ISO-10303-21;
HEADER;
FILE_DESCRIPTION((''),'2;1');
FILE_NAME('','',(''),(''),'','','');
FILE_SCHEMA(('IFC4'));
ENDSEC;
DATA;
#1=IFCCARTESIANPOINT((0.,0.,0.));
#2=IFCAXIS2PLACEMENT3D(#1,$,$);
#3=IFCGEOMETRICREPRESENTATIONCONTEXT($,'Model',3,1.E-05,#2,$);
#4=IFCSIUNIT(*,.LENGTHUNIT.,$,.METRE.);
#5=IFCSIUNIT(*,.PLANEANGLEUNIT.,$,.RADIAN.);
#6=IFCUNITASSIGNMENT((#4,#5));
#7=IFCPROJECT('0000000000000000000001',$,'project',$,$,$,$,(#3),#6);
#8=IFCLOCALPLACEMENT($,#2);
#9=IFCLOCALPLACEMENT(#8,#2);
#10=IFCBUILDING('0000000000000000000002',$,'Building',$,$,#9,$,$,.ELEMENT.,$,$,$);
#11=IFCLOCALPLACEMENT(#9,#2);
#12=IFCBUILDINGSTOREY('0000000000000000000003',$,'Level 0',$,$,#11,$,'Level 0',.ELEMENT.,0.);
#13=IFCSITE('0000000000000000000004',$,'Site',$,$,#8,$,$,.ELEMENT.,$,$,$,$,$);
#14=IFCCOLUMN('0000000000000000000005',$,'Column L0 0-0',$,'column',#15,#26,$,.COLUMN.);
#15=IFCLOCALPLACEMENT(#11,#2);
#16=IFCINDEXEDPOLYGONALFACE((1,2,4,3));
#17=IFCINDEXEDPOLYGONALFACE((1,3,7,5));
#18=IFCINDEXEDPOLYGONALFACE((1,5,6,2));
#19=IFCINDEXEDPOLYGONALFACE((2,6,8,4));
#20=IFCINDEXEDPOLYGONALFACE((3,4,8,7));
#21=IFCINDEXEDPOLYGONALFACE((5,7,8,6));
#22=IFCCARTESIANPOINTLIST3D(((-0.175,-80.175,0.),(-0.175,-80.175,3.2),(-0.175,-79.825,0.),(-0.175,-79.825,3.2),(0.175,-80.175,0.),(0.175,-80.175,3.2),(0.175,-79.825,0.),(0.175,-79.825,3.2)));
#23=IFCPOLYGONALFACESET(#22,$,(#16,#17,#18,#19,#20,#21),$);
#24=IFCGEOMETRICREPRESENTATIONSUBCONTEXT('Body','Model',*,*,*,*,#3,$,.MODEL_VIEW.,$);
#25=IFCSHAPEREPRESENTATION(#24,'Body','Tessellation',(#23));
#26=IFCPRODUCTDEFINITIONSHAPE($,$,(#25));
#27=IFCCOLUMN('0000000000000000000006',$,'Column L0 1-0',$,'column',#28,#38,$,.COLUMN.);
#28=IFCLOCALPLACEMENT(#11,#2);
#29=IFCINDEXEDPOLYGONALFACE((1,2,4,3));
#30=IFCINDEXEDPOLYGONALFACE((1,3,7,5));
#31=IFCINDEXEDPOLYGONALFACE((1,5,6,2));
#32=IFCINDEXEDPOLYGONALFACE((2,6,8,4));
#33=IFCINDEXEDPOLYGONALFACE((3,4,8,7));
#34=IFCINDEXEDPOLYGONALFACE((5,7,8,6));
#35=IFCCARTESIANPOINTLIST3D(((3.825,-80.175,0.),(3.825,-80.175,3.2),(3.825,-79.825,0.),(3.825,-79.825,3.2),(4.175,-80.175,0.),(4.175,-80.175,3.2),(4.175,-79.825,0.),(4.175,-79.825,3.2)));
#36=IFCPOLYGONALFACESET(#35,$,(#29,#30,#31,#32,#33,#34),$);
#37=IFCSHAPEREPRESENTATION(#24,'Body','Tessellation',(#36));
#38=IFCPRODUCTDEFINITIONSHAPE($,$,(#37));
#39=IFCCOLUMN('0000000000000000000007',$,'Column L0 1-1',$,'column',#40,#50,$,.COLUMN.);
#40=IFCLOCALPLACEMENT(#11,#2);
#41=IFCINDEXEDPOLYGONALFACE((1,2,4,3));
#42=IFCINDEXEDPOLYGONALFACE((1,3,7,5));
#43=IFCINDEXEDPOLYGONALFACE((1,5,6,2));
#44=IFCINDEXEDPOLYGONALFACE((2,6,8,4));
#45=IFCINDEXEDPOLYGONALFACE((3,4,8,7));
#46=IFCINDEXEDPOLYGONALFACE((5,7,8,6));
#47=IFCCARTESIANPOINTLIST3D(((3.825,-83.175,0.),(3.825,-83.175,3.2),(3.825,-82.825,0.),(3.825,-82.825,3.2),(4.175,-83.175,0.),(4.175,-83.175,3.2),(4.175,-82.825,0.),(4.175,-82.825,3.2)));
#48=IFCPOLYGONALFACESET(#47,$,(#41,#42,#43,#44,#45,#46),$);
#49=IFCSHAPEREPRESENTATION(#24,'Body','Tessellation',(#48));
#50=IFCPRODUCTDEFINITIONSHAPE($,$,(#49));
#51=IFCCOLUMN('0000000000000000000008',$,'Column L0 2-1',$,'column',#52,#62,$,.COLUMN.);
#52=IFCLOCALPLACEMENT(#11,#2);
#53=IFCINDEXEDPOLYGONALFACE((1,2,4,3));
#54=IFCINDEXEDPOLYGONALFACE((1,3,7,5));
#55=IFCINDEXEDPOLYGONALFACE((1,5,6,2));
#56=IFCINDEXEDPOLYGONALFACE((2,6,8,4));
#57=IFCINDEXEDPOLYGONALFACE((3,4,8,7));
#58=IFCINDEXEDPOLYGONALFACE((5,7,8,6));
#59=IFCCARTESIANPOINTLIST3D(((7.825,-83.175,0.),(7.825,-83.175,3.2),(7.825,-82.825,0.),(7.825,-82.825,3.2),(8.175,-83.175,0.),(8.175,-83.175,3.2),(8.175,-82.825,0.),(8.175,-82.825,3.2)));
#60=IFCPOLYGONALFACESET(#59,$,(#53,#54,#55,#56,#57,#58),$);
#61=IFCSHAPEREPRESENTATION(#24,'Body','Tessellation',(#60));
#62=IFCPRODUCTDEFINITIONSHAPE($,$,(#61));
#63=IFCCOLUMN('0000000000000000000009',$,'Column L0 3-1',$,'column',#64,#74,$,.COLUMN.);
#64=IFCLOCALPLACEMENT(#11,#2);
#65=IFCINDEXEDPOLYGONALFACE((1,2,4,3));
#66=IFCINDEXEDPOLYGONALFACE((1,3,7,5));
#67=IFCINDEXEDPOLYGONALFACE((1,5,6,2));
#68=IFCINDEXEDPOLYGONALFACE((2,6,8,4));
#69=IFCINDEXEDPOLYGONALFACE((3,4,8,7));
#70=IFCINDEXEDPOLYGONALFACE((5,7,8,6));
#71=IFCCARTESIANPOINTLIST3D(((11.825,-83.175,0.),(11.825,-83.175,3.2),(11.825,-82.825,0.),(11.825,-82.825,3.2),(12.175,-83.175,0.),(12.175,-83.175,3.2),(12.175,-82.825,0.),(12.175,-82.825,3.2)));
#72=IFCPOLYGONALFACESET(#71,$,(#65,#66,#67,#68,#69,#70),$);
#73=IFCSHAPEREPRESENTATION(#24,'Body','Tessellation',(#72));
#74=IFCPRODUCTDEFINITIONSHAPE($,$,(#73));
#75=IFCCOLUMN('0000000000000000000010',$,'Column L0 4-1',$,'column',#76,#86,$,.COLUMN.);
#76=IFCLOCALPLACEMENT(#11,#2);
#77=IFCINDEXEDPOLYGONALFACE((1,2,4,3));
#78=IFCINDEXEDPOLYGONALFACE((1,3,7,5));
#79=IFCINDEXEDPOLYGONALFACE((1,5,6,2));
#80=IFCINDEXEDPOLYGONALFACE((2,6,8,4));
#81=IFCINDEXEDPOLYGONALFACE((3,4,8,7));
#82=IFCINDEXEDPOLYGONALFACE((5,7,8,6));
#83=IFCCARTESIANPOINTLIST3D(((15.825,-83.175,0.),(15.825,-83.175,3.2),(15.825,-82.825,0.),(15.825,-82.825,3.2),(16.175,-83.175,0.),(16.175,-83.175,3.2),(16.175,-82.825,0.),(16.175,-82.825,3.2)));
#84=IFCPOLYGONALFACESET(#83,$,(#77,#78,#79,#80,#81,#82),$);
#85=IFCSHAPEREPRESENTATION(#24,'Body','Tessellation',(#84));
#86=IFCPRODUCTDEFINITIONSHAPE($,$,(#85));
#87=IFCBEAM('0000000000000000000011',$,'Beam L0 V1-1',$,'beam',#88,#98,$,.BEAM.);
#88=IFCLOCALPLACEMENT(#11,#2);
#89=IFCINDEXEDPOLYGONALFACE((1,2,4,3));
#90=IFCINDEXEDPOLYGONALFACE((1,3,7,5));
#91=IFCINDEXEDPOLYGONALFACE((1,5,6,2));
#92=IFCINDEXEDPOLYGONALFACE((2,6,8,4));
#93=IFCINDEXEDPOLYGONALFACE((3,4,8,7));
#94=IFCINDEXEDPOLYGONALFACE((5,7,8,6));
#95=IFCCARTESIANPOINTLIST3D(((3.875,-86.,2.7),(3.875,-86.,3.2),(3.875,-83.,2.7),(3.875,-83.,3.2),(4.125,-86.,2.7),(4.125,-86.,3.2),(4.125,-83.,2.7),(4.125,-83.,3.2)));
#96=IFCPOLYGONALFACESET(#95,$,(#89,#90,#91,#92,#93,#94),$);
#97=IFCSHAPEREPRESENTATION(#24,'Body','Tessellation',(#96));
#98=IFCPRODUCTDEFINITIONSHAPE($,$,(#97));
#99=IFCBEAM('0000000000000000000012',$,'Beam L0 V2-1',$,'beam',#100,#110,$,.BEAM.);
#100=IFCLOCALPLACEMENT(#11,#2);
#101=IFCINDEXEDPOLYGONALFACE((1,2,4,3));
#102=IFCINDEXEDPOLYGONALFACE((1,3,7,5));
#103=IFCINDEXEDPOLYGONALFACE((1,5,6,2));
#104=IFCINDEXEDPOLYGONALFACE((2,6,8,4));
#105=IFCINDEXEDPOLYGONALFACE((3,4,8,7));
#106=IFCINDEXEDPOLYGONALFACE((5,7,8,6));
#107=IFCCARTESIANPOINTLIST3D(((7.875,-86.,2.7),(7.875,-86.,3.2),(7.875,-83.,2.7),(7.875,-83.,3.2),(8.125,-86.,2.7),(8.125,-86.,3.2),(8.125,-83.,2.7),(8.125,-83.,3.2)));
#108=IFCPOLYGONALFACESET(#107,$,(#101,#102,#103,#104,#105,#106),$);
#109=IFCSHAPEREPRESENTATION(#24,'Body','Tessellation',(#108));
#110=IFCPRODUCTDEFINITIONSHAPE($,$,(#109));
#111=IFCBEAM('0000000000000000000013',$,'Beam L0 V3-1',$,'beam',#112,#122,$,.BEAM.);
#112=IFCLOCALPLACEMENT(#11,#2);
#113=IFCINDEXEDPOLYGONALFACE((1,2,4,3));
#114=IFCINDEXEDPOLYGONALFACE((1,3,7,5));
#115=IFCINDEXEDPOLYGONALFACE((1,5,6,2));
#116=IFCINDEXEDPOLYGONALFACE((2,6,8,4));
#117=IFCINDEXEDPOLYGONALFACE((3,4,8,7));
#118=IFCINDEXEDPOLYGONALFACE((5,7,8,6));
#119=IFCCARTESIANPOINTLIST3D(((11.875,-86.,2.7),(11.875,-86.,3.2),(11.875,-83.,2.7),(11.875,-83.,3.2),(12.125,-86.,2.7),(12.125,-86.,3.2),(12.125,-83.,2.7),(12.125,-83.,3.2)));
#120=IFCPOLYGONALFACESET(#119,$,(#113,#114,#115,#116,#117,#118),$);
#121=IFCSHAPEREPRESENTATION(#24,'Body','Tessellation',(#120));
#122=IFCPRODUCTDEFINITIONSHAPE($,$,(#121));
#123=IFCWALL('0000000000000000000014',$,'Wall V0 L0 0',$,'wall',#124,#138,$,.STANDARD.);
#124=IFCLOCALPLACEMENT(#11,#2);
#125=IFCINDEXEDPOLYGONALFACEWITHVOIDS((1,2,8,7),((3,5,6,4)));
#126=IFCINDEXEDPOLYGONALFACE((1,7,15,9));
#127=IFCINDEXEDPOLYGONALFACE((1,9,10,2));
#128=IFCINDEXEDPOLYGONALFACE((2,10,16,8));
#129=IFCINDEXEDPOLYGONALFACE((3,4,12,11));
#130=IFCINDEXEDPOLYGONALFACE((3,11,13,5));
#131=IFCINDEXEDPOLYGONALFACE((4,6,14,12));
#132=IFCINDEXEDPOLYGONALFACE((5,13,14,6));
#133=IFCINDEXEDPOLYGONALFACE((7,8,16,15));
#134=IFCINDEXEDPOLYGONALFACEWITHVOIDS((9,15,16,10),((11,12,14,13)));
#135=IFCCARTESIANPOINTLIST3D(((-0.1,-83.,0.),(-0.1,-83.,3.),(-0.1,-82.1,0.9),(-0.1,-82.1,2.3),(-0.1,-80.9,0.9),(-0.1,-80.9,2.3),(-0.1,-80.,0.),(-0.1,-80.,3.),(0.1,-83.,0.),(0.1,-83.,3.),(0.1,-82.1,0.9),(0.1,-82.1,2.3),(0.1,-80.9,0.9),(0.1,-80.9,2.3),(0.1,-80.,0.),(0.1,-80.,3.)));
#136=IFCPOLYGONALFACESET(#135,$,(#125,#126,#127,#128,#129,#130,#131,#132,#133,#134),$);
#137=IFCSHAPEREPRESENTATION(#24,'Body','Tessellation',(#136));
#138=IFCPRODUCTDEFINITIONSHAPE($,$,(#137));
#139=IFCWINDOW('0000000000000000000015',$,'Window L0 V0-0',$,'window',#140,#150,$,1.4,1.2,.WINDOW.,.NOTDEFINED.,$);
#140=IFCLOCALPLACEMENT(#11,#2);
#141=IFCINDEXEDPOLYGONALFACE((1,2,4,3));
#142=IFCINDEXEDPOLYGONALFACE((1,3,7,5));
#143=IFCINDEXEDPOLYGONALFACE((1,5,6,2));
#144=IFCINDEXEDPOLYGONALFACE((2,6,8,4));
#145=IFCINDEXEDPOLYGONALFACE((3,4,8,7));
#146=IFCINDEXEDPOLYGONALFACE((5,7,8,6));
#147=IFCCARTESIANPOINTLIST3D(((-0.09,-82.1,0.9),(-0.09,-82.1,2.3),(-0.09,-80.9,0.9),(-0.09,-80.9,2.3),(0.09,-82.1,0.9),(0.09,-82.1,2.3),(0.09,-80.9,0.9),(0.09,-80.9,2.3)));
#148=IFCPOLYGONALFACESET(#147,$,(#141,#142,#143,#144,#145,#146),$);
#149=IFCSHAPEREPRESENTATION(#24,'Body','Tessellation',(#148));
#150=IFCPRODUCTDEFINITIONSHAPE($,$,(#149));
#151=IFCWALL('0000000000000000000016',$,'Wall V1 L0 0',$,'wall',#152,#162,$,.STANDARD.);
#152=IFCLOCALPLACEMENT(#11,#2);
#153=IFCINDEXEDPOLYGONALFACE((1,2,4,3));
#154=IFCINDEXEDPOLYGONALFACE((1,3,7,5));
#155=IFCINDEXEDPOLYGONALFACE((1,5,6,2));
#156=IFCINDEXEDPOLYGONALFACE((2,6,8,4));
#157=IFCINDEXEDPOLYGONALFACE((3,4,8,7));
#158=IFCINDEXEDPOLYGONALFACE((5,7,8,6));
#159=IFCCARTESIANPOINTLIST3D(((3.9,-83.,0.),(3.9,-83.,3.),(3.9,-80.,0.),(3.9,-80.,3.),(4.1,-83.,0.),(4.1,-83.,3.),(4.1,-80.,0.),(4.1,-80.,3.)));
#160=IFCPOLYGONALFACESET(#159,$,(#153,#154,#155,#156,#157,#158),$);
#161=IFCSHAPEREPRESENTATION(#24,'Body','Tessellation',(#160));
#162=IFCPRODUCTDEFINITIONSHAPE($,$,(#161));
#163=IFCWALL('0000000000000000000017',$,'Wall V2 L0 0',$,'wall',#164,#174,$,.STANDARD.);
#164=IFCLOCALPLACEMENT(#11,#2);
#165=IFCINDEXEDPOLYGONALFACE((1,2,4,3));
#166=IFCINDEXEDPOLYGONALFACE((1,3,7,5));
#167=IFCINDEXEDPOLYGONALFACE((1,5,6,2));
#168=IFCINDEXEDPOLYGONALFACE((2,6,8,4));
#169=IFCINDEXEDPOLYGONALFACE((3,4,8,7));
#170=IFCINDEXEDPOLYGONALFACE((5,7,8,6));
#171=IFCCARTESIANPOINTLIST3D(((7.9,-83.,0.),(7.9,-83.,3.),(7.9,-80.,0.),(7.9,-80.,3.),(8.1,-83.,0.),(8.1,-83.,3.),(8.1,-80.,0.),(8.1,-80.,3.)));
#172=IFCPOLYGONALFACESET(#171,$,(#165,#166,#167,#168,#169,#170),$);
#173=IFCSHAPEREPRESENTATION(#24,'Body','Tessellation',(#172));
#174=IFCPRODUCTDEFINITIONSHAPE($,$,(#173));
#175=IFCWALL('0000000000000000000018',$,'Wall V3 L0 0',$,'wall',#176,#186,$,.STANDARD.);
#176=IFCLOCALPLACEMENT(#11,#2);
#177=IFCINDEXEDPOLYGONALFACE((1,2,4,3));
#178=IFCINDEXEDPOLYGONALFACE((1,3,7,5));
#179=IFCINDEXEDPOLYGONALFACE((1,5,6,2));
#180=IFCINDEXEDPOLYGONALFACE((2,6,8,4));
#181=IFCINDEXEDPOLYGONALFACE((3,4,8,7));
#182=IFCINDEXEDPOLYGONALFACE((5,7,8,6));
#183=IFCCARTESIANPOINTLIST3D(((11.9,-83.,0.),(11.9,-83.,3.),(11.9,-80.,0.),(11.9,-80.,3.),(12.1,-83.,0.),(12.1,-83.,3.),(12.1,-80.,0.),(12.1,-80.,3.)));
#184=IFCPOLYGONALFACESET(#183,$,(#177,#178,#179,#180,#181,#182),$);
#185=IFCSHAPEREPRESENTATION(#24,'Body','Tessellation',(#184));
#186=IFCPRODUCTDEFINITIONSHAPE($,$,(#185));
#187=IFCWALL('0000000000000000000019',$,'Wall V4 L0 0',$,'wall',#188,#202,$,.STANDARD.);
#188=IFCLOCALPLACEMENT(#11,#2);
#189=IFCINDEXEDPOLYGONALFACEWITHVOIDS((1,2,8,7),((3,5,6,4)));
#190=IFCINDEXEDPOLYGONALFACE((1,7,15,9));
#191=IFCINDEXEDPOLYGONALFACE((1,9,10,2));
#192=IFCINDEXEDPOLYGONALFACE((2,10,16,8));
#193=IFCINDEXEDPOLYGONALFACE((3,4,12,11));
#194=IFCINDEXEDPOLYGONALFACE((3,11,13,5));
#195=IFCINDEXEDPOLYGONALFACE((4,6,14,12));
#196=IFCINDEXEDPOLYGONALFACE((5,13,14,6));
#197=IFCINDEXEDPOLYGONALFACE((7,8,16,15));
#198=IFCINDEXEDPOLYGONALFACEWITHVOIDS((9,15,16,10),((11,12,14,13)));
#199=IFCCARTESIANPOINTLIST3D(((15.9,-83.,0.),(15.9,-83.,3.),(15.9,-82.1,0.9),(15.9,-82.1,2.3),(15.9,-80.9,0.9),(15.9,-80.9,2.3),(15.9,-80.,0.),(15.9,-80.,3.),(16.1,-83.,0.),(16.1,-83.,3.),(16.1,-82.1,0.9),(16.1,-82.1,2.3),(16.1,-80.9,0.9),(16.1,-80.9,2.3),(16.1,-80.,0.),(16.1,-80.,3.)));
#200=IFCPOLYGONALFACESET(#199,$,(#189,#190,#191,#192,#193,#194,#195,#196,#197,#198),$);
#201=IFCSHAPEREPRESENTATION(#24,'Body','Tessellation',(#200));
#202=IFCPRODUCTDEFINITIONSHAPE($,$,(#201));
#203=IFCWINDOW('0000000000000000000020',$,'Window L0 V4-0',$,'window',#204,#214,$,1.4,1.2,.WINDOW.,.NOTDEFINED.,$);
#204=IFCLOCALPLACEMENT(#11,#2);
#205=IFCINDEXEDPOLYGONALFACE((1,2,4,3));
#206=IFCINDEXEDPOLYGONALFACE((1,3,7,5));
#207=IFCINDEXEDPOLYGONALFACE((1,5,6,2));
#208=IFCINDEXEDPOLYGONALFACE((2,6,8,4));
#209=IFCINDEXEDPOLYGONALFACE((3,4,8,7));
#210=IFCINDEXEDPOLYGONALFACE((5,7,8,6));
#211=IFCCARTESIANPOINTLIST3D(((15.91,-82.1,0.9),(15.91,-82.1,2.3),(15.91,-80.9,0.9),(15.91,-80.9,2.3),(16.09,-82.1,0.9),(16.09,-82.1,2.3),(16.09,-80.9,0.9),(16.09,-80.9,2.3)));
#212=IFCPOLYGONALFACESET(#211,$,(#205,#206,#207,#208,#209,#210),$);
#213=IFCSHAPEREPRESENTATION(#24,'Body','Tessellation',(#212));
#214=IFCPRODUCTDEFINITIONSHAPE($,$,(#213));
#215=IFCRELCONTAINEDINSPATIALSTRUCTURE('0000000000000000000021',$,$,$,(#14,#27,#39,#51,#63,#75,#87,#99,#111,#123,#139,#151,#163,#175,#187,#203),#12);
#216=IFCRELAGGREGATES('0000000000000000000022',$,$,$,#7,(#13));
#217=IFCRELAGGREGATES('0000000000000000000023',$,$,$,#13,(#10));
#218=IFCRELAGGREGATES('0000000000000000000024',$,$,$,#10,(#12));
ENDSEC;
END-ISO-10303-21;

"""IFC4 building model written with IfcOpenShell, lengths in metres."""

from ifc_helpers import new_model, si_unit, frame, frame_2d, origin, origin_2d, place, context, subcontext, project, spatial, rectangle, extrude, element, fill, save


model = new_model("IFC4")

# Units and contexts
model_context = context("Model", 3, precision=1e-05, world=origin())
body_context = subcontext(model_context, "Body", "Model", "MODEL_VIEW")
ifc_project = project(units=[si_unit("LENGTHUNIT", "METRE"), si_unit("PLANEANGLEUNIT", "RADIAN")], contexts=[model_context])

# Site, building, storey
site_placement = place(None, origin())
site = spatial("IfcSite", under=ifc_project, at=site_placement, Name="Site", CompositionType="ELEMENT")
building_placement = place(site_placement, origin())
building = spatial("IfcBuilding", under=site, at=building_placement, Name="Building", CompositionType="ELEMENT")
storey_placement = place(building_placement, origin())
storey = spatial("IfcBuildingStorey", under=building, at=storey_placement, Name="Level 0", LongName="Level 0", CompositionType="ELEMENT", Elevation=0.0)

# Columns
for number, where, name in (
    (1, (0.0, -80.0, 0.0), "Column L0 0-0"),
    (2, (4.0, -80.0, 0.0), "Column L0 1-0"),
    (3, (4.0, -83.0, 0.0), "Column L0 1-1"),
    (4, (8.0, -83.0, 0.0), "Column L0 2-1"),
    (5, (12.0, -83.0, 0.0), "Column L0 3-1"),
    (6, (16.0, -83.0, 0.0), "Column L0 4-1"),
):
    element("IfcColumn", number, at=place(storey_placement, frame(where)), inside=storey, Name=name, ObjectType="column", PredefinedType="COLUMN", context=body_context, shape_type="SweptSolid", body=[
        extrude(rectangle(XDim=0.35, YDim=0.35, at=origin_2d()), origin(), (0.0, 0.0, 1.0), 3.2),
    ])

# Beams
for number, where, z_axis, x_axis, name in (
    (7, (4.0, -83.0, 2.95), (0.0, -1.0, 0.0), (0.0, 0.0, 1.0), "Beam L0 V1-1"),
    (8, (8.0, -83.0, 2.95), (0.0, -1.0, 0.0), (0.0, 0.0, 1.0), "Beam L0 V2-1"),
    (9, (12.0, -83.0, 2.95), (0.0, -1.0, 0.0), (0.0, 0.0, 1.0), "Beam L0 V3-1"),
):
    element("IfcBeam", number, at=place(storey_placement, frame(where, z_axis=z_axis, x_axis=x_axis)), inside=storey, Name=name, ObjectType="beam", PredefinedType="BEAM", context=body_context, shape_type="SweptSolid", body=[
        extrude(rectangle(XDim=0.5, YDim=0.25, at=origin_2d()), origin(), (0.0, 0.0, 1.0), 3.0),
    ])

# Wall, opening, window
wall_1_placement = place(storey_placement, frame((0.0, -80.0, 0.0), z_axis=(0.0, 0.0, 1.0), x_axis=(0.0, -1.0, 0.0)))
wall_1 = element("IfcWall", 10, at=wall_1_placement, inside=storey, Name="Wall V0 L0 0", ObjectType="wall", PredefinedType="STANDARD", context=body_context, shape_type="SweptSolid", body=[
    extrude(rectangle(XDim=3.0, YDim=0.2, at=frame_2d((1.5, 0.0))), origin(), (0.0, 0.0, 1.0), 3.0),
])
opening_1_placement = place(storey_placement, frame((0.0, -81.5, 0.9), z_axis=(0.0, 0.0, 1.0), x_axis=(0.0, -1.0, 0.0)))
opening_1 = element("IfcOpeningElement", 11, at=opening_1_placement, cuts=wall_1, ObjectType="Opening", PredefinedType="OPENING", context=body_context, shape_type="SweptSolid", body=[
    extrude(rectangle(XDim=1.2, YDim=0.22, at=origin_2d()), origin(), (0.0, 0.0, 1.0), 1.4),
])
window_1_placement = place(storey_placement, frame((0.0, -81.5, 0.9), z_axis=(0.0, 0.0, 1.0), x_axis=(0.0, -1.0, 0.0)))
window_1 = element("IfcWindow", 12, at=window_1_placement, inside=storey, Name="Window L0 V0-0", ObjectType="window", OverallHeight=1.4, OverallWidth=1.2, PartitioningType="NOTDEFINED", PredefinedType="WINDOW", context=body_context, shape_type="SweptSolid", body=[
    extrude(rectangle(XDim=1.2, YDim=0.18, at=origin_2d()), origin(), (0.0, 0.0, 1.0), 1.4),
])
fill(opening_1, window_1)

# Walls
for number, where, z_axis, x_axis, name in (
    (13, (4.0, -80.0, 0.0), (0.0, 0.0, 1.0), (0.0, -1.0, 0.0), "Wall V1 L0 0"),
    (14, (8.0, -80.0, 0.0), (0.0, 0.0, 1.0), (0.0, -1.0, 0.0), "Wall V2 L0 0"),
    (15, (12.0, -80.0, 0.0), (0.0, 0.0, 1.0), (0.0, -1.0, 0.0), "Wall V3 L0 0"),
):
    element("IfcWall", number, at=place(storey_placement, frame(where, z_axis=z_axis, x_axis=x_axis)), inside=storey, Name=name, ObjectType="wall", PredefinedType="STANDARD", context=body_context, shape_type="SweptSolid", body=[
        extrude(rectangle(XDim=3.0, YDim=0.2, at=frame_2d((1.5, 0.0))), origin(), (0.0, 0.0, 1.0), 3.0),
    ])

# Wall, opening, window
wall_2_placement = place(storey_placement, frame((16.0, -80.0, 0.0), z_axis=(0.0, 0.0, 1.0), x_axis=(0.0, -1.0, 0.0)))
wall_2 = element("IfcWall", 16, at=wall_2_placement, inside=storey, Name="Wall V4 L0 0", ObjectType="wall", PredefinedType="STANDARD", context=body_context, shape_type="SweptSolid", body=[
    extrude(rectangle(XDim=3.0, YDim=0.2, at=frame_2d((1.5, 0.0))), origin(), (0.0, 0.0, 1.0), 3.0),
])
opening_2_placement = place(storey_placement, frame((16.0, -81.5, 0.9), z_axis=(0.0, 0.0, 1.0), x_axis=(0.0, -1.0, 0.0)))
opening_2 = element("IfcOpeningElement", 17, at=opening_2_placement, cuts=wall_2, ObjectType="Opening", PredefinedType="OPENING", context=body_context, shape_type="SweptSolid", body=[
    extrude(rectangle(XDim=1.2, YDim=0.22, at=origin_2d()), origin(), (0.0, 0.0, 1.0), 1.4),
])
window_2_placement = place(storey_placement, frame((16.0, -81.5, 0.9), z_axis=(0.0, 0.0, 1.0), x_axis=(0.0, -1.0, 0.0)))
window_2 = element("IfcWindow", 18, at=window_2_placement, inside=storey, Name="Window L0 V4-0", ObjectType="window", OverallHeight=1.4, OverallWidth=1.2, PartitioningType="NOTDEFINED", PredefinedType="WINDOW", context=body_context, shape_type="SweptSolid", body=[
    extrude(rectangle(XDim=1.2, YDim=0.18, at=origin_2d()), origin(), (0.0, 0.0, 1.0), 1.4),
])
fill(opening_2, window_2)

save(model, "model.ifc")
